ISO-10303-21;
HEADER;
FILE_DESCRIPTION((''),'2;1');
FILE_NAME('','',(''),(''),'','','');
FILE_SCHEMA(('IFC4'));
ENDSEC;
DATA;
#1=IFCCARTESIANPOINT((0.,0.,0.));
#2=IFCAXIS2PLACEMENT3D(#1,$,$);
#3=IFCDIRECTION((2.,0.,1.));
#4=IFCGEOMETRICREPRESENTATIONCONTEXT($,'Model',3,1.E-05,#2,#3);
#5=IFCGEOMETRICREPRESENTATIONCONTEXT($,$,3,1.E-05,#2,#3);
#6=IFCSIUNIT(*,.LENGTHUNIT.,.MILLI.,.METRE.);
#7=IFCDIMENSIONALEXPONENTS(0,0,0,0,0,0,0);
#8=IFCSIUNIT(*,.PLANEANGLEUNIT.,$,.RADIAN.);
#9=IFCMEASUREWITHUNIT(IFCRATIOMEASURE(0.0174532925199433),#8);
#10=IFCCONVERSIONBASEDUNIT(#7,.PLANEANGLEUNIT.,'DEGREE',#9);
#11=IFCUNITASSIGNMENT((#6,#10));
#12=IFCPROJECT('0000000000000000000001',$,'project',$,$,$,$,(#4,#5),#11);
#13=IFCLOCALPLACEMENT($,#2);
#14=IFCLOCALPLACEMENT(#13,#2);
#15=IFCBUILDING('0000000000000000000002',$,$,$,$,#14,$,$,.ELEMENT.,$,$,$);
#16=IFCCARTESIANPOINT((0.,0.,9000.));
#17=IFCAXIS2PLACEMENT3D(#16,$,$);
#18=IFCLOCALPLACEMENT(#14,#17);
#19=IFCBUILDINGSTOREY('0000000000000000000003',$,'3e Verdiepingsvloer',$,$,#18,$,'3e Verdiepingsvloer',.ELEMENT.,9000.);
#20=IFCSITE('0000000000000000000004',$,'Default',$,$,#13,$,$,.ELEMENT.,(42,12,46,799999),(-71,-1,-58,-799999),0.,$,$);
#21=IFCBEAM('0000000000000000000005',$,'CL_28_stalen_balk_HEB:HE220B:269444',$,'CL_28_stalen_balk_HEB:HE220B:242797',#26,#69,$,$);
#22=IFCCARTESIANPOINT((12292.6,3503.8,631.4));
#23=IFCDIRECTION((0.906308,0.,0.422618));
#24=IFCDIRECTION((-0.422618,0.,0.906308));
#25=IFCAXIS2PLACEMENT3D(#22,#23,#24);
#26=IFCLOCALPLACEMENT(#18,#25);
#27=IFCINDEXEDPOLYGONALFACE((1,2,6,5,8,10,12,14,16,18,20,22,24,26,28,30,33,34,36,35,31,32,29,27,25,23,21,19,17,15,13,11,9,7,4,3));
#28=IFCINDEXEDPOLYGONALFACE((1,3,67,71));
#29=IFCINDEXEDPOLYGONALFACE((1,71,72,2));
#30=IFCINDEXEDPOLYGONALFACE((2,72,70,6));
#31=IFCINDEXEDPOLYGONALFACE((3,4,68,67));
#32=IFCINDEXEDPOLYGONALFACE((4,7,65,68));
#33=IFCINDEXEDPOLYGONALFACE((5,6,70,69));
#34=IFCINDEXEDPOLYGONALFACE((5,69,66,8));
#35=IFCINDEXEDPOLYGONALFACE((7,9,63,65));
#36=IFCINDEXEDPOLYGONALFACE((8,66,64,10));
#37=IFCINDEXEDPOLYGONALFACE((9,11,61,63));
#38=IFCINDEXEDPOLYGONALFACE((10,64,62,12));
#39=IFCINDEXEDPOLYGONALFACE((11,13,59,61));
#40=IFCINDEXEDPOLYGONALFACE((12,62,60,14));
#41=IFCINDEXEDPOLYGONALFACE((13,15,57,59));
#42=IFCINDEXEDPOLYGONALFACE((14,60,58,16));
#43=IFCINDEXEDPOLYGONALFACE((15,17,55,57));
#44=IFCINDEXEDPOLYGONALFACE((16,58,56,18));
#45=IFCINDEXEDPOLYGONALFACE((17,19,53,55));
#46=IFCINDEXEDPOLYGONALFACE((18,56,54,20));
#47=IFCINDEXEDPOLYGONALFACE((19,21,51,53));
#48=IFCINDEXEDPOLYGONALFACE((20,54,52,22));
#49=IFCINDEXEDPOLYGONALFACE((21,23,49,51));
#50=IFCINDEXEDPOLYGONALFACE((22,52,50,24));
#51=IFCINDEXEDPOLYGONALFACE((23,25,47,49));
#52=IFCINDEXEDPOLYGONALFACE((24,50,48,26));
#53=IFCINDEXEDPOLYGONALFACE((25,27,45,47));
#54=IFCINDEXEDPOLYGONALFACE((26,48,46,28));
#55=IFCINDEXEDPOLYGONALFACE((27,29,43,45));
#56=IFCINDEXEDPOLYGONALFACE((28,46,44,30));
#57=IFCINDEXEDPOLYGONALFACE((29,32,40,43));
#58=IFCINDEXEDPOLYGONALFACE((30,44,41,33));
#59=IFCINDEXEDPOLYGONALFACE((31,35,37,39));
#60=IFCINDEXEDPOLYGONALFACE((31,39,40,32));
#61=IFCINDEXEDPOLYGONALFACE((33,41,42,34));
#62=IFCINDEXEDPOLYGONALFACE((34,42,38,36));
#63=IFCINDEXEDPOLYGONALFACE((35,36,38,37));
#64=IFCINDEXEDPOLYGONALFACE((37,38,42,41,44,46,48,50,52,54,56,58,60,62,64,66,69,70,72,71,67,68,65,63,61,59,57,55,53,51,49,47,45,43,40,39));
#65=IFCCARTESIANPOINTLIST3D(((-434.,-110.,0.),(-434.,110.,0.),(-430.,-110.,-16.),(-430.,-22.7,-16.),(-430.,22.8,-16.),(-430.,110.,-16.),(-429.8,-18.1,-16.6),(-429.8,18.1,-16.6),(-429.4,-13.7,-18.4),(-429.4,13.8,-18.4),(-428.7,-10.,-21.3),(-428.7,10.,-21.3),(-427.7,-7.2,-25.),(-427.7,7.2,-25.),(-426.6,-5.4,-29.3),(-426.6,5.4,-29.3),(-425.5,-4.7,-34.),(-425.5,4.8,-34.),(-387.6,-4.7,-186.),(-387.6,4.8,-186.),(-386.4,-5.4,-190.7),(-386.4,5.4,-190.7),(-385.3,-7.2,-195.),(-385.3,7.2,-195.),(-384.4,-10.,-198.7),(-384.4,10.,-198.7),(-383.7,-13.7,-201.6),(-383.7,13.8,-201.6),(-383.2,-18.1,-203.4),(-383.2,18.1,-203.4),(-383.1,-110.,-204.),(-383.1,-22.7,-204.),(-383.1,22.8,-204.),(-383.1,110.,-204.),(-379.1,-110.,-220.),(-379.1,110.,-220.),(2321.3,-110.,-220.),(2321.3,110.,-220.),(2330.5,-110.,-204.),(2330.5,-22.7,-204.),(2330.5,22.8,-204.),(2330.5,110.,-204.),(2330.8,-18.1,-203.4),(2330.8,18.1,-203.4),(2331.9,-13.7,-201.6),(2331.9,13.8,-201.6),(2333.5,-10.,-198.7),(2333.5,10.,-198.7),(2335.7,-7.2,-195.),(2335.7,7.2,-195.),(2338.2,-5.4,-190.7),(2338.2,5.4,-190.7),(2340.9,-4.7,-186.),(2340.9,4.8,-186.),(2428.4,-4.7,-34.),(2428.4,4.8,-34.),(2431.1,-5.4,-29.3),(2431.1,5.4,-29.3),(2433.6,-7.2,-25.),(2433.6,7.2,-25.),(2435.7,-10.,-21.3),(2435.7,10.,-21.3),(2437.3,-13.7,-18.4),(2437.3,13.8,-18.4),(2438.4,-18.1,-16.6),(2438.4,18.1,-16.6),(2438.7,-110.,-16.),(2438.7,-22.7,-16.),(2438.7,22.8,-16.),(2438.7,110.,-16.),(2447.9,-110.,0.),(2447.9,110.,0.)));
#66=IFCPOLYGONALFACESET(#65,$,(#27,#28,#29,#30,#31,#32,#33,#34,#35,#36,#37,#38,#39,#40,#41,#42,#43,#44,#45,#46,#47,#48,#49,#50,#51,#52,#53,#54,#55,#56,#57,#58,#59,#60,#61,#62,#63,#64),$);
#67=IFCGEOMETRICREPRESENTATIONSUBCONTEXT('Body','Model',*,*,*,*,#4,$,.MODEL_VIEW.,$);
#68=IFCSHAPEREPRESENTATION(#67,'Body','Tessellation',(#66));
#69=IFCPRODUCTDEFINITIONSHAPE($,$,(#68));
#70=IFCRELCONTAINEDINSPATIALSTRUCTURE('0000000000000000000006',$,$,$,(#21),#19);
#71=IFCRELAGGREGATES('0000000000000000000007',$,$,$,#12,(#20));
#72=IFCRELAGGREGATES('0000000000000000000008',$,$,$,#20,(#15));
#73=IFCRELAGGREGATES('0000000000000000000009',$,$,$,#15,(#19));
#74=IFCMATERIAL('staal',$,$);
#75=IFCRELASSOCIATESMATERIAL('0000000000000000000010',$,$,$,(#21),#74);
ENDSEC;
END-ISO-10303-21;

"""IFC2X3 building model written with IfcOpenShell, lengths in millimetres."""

from ifc_helpers import new_model, entity, si_unit, converted_unit, direction, frame, frame_2d, origin, place, context, subcontext, project, spatial, i_section, extrude, clip, halfspace, material, element, save


model = new_model("IFC2X3")

# Units and contexts
model_context = context("Model", 3, precision=1e-05, world=origin(), true_north=direction((2.0, 0.0, 1.0)))
context_of_model = context(None, 3, precision=1e-05, world=origin(), true_north=direction((2.0, 0.0, 1.0)))
body_context = subcontext(model_context, "Body", "Model", "MODEL_VIEW")
ifc_project = project(units=[si_unit("LENGTHUNIT", "METRE", prefix="MILLI"), converted_unit("PLANEANGLEUNIT", "DEGREE", entity("IfcRatioMeasure", 0.0174532925199433), si_unit("PLANEANGLEUNIT", "RADIAN"), dimensions=[0, 0, 0, 0, 0, 0, 0])], contexts=[model_context, context_of_model])

# Site, building, storey
site_placement = place(None, origin())
site = spatial("IfcSite", under=ifc_project, at=site_placement, Name="Default", CompositionType="ELEMENT", RefLatitude=(42, 12, 46, 799999), RefLongitude=(-71, -1, -58, -799999), RefElevation=0.0)
building_placement = place(site_placement, origin())
building = spatial("IfcBuilding", under=site, at=building_placement, CompositionType="ELEMENT")
storey_placement = place(building_placement, frame((0.0, 0.0, 9000.0)))
storey = spatial("IfcBuildingStorey", under=building, at=storey_placement, Name="3e Verdiepingsvloer", LongName="3e Verdiepingsvloer", CompositionType="ELEMENT", Elevation=9000.0)

# Beam
ifc_material_1 = material(Name="staal")
beam_1_placement = place(storey_placement, frame((12292.6, 3503.8, 631.4), z_axis=(0.906308, 0.0, 0.422618), x_axis=(-0.422618, 0.0, 0.906308)))
element("IfcBeam", 1, at=beam_1_placement, inside=storey, material=ifc_material_1, Name="CL_28_stalen_balk_HEB:HE220B:269444", ObjectType="CL_28_stalen_balk_HEB:HE220B:242797", context=body_context, shape_type="Clipping", body=[
    clip(clip(extrude(i_section(OverallWidth=220.0, OverallDepth=220.0, WebThickness=9.5, FlangeThickness=16.0, FilletRadius=18.0, at=frame_2d((0.0, 0.0), x_axis=(0.0, 1.0))), frame((-434.0, 0.0, -110.0), z_axis=(1.0, 0.0, 0.0), x_axis=(0.0, 0.0, -1.0)), (0.0, 0.0, 1.0), 2881.9), halfspace(frame((-475.4, -2115.1, 166.1), z_axis=(-0.970296, 0.0, -0.241922), x_axis=(-0.241922, 0.0, 0.970296)), False)), halfspace(frame((2447.9, -2115.1, 0.0), z_axis=(0.86662, 0.0, -0.498969), x_axis=(0.498969, 0.0, 0.86662)), False)),
])

save(model, "model.ifc")
